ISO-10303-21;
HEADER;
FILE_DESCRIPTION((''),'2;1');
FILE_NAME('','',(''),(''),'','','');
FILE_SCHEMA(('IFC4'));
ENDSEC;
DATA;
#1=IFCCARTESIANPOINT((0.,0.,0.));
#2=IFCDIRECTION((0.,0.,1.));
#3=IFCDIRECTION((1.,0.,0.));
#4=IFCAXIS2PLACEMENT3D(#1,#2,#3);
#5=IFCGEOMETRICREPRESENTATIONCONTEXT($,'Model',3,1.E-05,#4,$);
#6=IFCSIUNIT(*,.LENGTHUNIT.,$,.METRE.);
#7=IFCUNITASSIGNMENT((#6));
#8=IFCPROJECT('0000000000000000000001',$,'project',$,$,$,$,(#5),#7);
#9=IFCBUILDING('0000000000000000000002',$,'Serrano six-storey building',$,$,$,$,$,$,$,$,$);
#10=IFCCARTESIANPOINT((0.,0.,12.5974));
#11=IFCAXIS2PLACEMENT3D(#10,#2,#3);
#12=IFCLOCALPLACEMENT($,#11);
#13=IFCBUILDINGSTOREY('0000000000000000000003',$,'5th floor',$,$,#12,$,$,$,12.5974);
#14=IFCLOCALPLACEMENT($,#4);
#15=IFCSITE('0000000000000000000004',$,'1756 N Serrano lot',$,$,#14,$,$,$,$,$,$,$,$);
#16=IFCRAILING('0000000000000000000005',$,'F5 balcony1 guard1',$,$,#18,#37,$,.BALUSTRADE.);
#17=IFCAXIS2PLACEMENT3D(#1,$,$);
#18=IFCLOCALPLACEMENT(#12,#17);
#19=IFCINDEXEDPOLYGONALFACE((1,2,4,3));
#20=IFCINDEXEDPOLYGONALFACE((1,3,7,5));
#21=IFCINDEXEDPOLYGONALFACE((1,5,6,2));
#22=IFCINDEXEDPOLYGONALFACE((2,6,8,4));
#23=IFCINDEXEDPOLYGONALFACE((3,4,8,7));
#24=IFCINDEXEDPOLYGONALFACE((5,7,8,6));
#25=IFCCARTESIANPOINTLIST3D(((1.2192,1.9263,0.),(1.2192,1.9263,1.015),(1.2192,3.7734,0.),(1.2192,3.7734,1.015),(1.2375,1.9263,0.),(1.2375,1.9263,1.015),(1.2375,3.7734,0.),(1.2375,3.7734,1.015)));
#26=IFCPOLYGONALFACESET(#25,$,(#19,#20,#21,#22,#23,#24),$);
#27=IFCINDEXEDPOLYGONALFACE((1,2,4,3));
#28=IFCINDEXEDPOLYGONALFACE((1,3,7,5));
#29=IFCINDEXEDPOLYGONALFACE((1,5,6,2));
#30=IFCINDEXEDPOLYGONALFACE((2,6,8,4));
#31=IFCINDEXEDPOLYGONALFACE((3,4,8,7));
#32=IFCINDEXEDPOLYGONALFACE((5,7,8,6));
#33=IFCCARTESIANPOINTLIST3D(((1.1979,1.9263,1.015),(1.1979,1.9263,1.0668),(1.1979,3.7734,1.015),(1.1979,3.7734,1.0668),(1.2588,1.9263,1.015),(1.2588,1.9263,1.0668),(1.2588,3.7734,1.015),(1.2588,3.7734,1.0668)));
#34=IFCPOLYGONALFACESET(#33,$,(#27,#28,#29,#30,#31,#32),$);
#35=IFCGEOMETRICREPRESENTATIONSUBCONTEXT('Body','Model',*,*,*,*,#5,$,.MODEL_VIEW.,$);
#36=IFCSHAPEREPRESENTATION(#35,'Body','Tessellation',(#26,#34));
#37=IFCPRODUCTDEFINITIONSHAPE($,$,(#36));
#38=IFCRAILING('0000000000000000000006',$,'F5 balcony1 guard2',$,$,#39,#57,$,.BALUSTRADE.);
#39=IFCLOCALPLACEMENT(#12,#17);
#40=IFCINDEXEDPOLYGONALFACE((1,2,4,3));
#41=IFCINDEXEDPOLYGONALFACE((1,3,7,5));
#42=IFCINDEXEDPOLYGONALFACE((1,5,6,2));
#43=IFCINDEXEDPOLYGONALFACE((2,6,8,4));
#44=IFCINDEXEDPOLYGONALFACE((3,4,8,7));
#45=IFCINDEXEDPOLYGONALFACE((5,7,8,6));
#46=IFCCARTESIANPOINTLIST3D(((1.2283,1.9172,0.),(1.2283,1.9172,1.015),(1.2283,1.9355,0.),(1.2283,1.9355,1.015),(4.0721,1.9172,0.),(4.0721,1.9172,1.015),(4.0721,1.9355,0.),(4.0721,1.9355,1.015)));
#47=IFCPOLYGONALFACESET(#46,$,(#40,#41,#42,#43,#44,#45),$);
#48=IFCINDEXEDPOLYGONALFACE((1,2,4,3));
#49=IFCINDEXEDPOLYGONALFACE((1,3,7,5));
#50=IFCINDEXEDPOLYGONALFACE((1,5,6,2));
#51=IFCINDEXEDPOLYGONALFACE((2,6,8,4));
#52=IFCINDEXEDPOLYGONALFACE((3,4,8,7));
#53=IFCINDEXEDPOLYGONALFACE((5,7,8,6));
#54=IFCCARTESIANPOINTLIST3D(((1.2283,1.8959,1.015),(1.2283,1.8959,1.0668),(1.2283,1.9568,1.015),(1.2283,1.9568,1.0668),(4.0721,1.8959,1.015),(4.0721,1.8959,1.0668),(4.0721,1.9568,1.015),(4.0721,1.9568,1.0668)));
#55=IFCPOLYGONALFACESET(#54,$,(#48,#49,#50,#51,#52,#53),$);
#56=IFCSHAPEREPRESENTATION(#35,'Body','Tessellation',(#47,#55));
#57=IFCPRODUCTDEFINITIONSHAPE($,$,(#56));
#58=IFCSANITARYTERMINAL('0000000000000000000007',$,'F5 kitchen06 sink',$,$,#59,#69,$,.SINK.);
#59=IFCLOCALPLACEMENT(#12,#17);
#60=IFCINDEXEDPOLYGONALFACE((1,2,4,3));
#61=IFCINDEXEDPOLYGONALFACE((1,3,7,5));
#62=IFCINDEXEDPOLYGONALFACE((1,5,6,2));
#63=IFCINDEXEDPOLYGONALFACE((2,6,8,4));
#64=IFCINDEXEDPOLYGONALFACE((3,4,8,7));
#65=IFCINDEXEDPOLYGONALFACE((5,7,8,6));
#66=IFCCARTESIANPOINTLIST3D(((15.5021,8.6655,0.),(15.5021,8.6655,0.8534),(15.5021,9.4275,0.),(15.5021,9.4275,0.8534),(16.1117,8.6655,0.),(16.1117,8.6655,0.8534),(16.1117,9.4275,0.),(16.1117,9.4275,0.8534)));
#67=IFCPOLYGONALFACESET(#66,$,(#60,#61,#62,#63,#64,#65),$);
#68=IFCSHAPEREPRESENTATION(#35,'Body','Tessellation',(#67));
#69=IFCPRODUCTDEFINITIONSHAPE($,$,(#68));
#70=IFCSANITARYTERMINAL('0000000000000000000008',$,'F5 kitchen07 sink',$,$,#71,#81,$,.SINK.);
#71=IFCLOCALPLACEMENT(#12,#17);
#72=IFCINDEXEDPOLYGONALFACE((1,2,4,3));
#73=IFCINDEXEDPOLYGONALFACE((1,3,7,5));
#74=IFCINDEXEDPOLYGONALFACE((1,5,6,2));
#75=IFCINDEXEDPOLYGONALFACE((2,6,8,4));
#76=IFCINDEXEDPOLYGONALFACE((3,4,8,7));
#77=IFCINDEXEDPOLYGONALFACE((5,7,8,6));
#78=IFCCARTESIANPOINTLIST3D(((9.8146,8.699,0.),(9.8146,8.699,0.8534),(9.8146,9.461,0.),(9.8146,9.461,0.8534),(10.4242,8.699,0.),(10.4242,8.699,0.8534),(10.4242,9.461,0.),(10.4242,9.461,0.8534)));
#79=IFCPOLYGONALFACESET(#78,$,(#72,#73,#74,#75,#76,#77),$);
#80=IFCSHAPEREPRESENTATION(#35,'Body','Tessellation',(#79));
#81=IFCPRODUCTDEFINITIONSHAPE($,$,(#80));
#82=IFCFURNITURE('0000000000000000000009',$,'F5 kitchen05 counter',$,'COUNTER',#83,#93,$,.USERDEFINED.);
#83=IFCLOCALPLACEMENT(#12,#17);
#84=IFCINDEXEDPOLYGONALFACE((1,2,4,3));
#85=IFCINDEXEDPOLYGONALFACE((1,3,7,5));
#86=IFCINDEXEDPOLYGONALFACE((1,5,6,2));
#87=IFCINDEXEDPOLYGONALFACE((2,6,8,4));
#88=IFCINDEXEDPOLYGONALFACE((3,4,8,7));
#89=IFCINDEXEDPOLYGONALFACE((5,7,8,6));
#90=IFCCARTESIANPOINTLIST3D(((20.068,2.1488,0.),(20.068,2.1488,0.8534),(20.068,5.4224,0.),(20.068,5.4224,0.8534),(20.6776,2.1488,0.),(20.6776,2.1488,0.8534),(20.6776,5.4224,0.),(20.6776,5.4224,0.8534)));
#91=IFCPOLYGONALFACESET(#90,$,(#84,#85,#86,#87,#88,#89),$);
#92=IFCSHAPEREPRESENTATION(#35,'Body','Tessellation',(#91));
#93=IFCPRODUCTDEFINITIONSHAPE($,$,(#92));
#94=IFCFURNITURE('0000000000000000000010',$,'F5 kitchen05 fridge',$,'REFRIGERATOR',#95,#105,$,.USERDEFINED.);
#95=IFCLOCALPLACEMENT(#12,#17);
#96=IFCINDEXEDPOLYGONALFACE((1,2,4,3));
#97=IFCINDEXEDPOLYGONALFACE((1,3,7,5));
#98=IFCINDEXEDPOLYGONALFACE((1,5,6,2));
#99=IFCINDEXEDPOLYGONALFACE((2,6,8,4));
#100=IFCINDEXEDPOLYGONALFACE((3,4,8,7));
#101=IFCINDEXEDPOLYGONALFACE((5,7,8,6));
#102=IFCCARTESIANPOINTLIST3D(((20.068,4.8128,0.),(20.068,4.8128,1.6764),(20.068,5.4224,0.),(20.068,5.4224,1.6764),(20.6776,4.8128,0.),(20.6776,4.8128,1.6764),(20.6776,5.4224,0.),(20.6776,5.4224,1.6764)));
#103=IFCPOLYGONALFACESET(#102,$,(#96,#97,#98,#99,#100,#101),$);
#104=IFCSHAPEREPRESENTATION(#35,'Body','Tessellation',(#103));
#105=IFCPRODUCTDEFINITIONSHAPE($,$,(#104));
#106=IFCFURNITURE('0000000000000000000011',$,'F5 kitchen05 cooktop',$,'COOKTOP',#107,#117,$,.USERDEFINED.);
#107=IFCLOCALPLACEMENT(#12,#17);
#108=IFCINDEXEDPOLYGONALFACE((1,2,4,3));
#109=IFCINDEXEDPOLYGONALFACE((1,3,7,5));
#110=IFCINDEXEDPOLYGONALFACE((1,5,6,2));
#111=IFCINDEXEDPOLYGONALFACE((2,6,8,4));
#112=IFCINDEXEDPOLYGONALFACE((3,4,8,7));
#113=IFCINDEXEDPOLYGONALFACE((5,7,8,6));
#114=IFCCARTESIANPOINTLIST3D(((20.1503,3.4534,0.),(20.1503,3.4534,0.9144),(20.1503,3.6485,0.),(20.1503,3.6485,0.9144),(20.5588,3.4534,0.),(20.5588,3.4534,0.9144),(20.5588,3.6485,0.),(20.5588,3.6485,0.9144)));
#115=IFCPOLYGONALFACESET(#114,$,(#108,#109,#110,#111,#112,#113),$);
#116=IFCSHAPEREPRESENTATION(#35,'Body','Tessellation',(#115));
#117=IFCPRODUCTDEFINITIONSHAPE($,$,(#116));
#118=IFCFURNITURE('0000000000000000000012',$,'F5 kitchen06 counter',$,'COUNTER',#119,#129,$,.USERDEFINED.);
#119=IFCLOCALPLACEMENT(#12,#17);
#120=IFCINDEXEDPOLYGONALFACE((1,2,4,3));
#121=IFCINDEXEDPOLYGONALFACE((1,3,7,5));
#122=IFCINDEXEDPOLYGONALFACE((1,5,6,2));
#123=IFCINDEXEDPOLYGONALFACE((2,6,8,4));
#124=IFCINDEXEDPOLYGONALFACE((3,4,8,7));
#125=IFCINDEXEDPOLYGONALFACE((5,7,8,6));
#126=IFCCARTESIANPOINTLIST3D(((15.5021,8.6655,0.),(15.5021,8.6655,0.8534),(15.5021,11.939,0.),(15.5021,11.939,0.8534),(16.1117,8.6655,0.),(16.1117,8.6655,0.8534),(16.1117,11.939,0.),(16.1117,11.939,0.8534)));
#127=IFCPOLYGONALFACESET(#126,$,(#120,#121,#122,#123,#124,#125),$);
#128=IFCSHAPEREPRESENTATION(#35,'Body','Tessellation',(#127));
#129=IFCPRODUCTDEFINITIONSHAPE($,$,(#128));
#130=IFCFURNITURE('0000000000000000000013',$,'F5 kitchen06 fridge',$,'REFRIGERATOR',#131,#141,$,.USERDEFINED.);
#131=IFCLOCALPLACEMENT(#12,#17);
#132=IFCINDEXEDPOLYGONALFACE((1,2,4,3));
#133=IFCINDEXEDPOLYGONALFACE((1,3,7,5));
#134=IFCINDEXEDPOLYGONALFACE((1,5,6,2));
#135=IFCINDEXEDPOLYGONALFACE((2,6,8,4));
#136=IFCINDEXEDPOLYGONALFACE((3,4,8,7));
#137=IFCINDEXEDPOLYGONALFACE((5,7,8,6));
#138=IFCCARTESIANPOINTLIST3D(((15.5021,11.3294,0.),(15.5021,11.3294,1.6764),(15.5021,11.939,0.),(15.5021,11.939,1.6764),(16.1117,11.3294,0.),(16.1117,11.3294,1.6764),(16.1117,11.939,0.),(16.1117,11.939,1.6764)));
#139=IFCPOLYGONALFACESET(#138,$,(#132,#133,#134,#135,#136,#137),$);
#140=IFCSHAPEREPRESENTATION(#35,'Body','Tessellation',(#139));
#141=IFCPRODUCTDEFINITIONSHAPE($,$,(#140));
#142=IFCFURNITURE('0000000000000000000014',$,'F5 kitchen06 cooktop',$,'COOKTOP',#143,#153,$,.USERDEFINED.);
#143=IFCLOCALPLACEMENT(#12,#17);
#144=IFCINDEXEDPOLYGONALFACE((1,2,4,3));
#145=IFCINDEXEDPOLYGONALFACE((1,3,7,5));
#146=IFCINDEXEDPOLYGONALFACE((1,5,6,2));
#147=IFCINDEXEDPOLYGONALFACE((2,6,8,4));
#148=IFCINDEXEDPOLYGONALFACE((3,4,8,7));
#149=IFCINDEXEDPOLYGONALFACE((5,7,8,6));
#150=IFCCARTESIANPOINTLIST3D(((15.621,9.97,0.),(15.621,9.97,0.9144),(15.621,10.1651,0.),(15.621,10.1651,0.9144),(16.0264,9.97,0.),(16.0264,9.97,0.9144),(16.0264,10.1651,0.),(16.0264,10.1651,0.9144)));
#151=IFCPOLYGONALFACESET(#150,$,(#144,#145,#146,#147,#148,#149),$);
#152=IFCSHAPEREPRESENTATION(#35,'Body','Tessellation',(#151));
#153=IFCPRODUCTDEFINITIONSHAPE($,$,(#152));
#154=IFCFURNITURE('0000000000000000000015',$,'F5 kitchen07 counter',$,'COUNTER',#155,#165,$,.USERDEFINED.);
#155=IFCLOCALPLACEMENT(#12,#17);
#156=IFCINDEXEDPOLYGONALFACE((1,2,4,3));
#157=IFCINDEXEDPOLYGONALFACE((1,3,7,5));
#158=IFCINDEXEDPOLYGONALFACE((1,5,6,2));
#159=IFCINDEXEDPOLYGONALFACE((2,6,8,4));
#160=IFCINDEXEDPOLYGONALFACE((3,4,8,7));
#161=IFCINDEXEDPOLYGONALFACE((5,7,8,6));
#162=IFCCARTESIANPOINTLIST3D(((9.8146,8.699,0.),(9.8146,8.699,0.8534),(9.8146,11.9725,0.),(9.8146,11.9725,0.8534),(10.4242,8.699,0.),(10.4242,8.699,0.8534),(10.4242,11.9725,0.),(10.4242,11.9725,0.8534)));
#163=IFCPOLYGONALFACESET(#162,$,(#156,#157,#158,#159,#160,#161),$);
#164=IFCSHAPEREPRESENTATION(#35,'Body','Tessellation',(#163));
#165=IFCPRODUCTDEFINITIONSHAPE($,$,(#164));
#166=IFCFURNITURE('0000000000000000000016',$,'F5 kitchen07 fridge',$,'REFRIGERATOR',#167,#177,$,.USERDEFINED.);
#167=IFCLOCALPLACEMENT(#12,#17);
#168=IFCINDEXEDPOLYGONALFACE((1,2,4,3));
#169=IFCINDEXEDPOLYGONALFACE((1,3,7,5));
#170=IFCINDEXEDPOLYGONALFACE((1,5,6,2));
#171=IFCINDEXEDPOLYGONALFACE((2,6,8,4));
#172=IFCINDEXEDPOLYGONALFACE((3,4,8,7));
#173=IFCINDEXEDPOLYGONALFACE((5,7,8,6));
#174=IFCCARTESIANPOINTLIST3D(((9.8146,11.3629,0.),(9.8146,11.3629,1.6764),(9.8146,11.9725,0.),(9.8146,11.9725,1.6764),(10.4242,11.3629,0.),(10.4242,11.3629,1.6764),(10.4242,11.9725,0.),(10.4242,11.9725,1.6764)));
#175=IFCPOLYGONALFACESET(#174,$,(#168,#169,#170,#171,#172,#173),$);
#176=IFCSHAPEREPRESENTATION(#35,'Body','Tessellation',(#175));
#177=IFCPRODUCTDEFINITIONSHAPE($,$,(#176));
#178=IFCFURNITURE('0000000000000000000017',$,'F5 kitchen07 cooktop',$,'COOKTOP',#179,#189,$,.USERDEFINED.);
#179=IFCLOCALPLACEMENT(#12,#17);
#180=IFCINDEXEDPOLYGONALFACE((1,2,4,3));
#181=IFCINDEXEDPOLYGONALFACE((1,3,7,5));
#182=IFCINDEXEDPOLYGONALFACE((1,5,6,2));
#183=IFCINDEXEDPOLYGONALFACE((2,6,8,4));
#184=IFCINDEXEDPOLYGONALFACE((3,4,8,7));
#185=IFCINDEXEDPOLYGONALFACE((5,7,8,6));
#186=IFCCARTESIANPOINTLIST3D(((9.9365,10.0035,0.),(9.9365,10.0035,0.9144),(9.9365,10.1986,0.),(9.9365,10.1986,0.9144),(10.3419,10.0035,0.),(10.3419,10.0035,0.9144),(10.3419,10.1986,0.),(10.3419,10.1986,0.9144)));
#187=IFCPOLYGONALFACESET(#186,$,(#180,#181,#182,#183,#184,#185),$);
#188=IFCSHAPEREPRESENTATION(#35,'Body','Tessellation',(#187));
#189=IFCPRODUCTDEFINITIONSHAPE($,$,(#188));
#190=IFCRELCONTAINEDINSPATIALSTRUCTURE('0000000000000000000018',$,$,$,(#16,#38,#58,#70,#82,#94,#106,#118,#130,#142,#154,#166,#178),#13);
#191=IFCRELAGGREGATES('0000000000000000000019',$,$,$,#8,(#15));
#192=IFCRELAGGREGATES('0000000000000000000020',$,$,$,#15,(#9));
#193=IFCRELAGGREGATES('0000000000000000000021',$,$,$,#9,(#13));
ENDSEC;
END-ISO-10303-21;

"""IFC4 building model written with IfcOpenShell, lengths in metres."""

from ifc_helpers import new_model, si_unit, frame, origin_with_axes, place, context, subcontext, project, spatial, polyline, outline, extrude, element, save


model = new_model("IFC4")

# Units and contexts
model_context = context("Model", 3, precision=1e-05, world=origin_with_axes())
body_context = subcontext(model_context, "Body", "Model", "MODEL_VIEW")
ifc_project = project(units=[si_unit("LENGTHUNIT", "METRE")], contexts=[model_context])

# Site, building, storey
site_placement = place(None, origin_with_axes())
site = spatial("IfcSite", under=ifc_project, at=site_placement, Name="1756 N Serrano lot")
building = spatial("IfcBuilding", under=site, Name="Serrano six-storey building")
storey_placement = place(None, frame((0.0, 0.0, 12.5974), z_axis=(0.0, 0.0, 1.0), x_axis=(1.0, 0.0, 0.0)))
storey = spatial("IfcBuildingStorey", under=building, at=storey_placement, Name="5th floor", Elevation=12.5974)

# Railings
railing_1_placement = place(storey_placement, frame((0.0, 0.0, -12.5974), z_axis=(0.0, 0.0, 1.0), x_axis=(1.0, 0.0, 0.0)))
element("IfcRailing", 1, at=railing_1_placement, inside=storey, Name="F5 balcony1 guard1", PredefinedType="BALUSTRADE", context=body_context, shape_type="SweptSolid", body=[
    extrude(outline(polyline([(1.2192, 3.7734), (1.2375, 3.7734), (1.2375, 1.9263), (1.2192, 1.9263), (1.2192, 3.7734)])), frame((0.0, 0.0, 12.5974)), (0.0, 0.0, 1.0), 1.015),
    extrude(outline(polyline([(1.1979, 3.7734), (1.2588, 3.7734), (1.2588, 1.9263), (1.1979, 1.9263), (1.1979, 3.7734)])), frame((0.0, 0.0, 13.6124)), (0.0, 0.0, 1.0), 0.0518),
])
railing_2_placement = place(storey_placement, frame((0.0, 0.0, -12.5974), z_axis=(0.0, 0.0, 1.0), x_axis=(1.0, 0.0, 0.0)))
element("IfcRailing", 2, at=railing_2_placement, inside=storey, Name="F5 balcony1 guard2", PredefinedType="BALUSTRADE", context=body_context, shape_type="SweptSolid", body=[
    extrude(outline(polyline([(1.2283, 1.9172), (1.2283, 1.9355), (4.0721, 1.9355), (4.0721, 1.9172), (1.2283, 1.9172)])), frame((0.0, 0.0, 12.5974)), (0.0, 0.0, 1.0), 1.015),
    extrude(outline(polyline([(1.2283, 1.8959), (1.2283, 1.9568), (4.0721, 1.9568), (4.0721, 1.8959), (1.2283, 1.8959)])), frame((0.0, 0.0, 13.6124)), (0.0, 0.0, 1.0), 0.0518),
])

# Sanitary terminals
sanitary_terminal_1_placement = place(storey_placement, frame((0.0, 0.0, -12.5974), z_axis=(0.0, 0.0, 1.0), x_axis=(1.0, 0.0, 0.0)))
element("IfcSanitaryTerminal", 3, at=sanitary_terminal_1_placement, inside=storey, Name="F5 kitchen06 sink", PredefinedType="SINK", context=body_context, shape_type="SweptSolid", body=[
    extrude(outline(polyline([(16.1117, 8.6655), (16.1117, 9.4275), (15.5021, 9.4275), (15.5021, 8.6655), (16.1117, 8.6655)])), frame((0.0, 0.0, 12.5974)), (0.0, 0.0, 1.0), 0.8534),
])
sanitary_terminal_2_placement = place(storey_placement, frame((0.0, 0.0, -12.5974), z_axis=(0.0, 0.0, 1.0), x_axis=(1.0, 0.0, 0.0)))
element("IfcSanitaryTerminal", 4, at=sanitary_terminal_2_placement, inside=storey, Name="F5 kitchen07 sink", PredefinedType="SINK", context=body_context, shape_type="SweptSolid", body=[
    extrude(outline(polyline([(10.4242, 8.699), (10.4242, 9.461), (9.8146, 9.461), (9.8146, 8.699), (10.4242, 8.699)])), frame((0.0, 0.0, 12.5974)), (0.0, 0.0, 1.0), 0.8534),
])

# Furniture
furniture_1_placement = place(storey_placement, frame((0.0, 0.0, -12.5974), z_axis=(0.0, 0.0, 1.0), x_axis=(1.0, 0.0, 0.0)))
element("IfcFurniture", 5, at=furniture_1_placement, inside=storey, Name="F5 kitchen05 counter", ObjectType="COUNTER", PredefinedType="USERDEFINED", context=body_context, shape_type="SweptSolid", body=[
    extrude(outline(polyline([(20.6776, 2.1488), (20.6776, 5.4224), (20.068, 5.4224), (20.068, 2.1488), (20.6776, 2.1488)])), frame((0.0, 0.0, 12.5974)), (0.0, 0.0, 1.0), 0.8534),
])
furniture_2_placement = place(storey_placement, frame((0.0, 0.0, -12.5974), z_axis=(0.0, 0.0, 1.0), x_axis=(1.0, 0.0, 0.0)))
element("IfcFurniture", 6, at=furniture_2_placement, inside=storey, Name="F5 kitchen05 fridge", ObjectType="REFRIGERATOR", PredefinedType="USERDEFINED", context=body_context, shape_type="SweptSolid", body=[
    extrude(outline(polyline([(20.6776, 4.8128), (20.6776, 5.4224), (20.068, 5.4224), (20.068, 4.8128), (20.6776, 4.8128)])), frame((0.0, 0.0, 12.5974)), (0.0, 0.0, 1.0), 1.6764),
])
furniture_3_placement = place(storey_placement, frame((0.0, 0.0, -12.5974), z_axis=(0.0, 0.0, 1.0), x_axis=(1.0, 0.0, 0.0)))
element("IfcFurniture", 7, at=furniture_3_placement, inside=storey, Name="F5 kitchen05 cooktop", ObjectType="COOKTOP", PredefinedType="USERDEFINED", context=body_context, shape_type="SweptSolid", body=[
    extrude(outline(polyline([(20.5588, 3.4534), (20.5588, 3.6485), (20.1503, 3.6485), (20.1503, 3.4534), (20.5588, 3.4534)])), frame((0.0, 0.0, 12.5974)), (0.0, 0.0, 1.0), 0.9144),
])
furniture_4_placement = place(storey_placement, frame((0.0, 0.0, -12.5974), z_axis=(0.0, 0.0, 1.0), x_axis=(1.0, 0.0, 0.0)))
element("IfcFurniture", 8, at=furniture_4_placement, inside=storey, Name="F5 kitchen06 counter", ObjectType="COUNTER", PredefinedType="USERDEFINED", context=body_context, shape_type="SweptSolid", body=[
    extrude(outline(polyline([(16.1117, 8.6655), (16.1117, 11.939), (15.5021, 11.939), (15.5021, 8.6655), (16.1117, 8.6655)])), frame((0.0, 0.0, 12.5974)), (0.0, 0.0, 1.0), 0.8534),
])
furniture_5_placement = place(storey_placement, frame((0.0, 0.0, -12.5974), z_axis=(0.0, 0.0, 1.0), x_axis=(1.0, 0.0, 0.0)))
element("IfcFurniture", 9, at=furniture_5_placement, inside=storey, Name="F5 kitchen06 fridge", ObjectType="REFRIGERATOR", PredefinedType="USERDEFINED", context=body_context, shape_type="SweptSolid", body=[
    extrude(outline(polyline([(16.1117, 11.3294), (16.1117, 11.939), (15.5021, 11.939), (15.5021, 11.3294), (16.1117, 11.3294)])), frame((0.0, 0.0, 12.5974)), (0.0, 0.0, 1.0), 1.6764),
])
furniture_6_placement = place(storey_placement, frame((0.0, 0.0, -12.5974), z_axis=(0.0, 0.0, 1.0), x_axis=(1.0, 0.0, 0.0)))
element("IfcFurniture", 10, at=furniture_6_placement, inside=storey, Name="F5 kitchen06 cooktop", ObjectType="COOKTOP", PredefinedType="USERDEFINED", context=body_context, shape_type="SweptSolid", body=[
    extrude(outline(polyline([(16.0264, 9.97), (16.0264, 10.1651), (15.621, 10.1651), (15.621, 9.97), (16.0264, 9.97)])), frame((0.0, 0.0, 12.5974)), (0.0, 0.0, 1.0), 0.9144),
])
furniture_7_placement = place(storey_placement, frame((0.0, 0.0, -12.5974), z_axis=(0.0, 0.0, 1.0), x_axis=(1.0, 0.0, 0.0)))
element("IfcFurniture", 11, at=furniture_7_placement, inside=storey, Name="F5 kitchen07 counter", ObjectType="COUNTER", PredefinedType="USERDEFINED", context=body_context, shape_type="SweptSolid", body=[
    extrude(outline(polyline([(10.4242, 8.699), (10.4242, 11.9725), (9.8146, 11.9725), (9.8146, 8.699), (10.4242, 8.699)])), frame((0.0, 0.0, 12.5974)), (0.0, 0.0, 1.0), 0.8534),
])
furniture_8_placement = place(storey_placement, frame((0.0, 0.0, -12.5974), z_axis=(0.0, 0.0, 1.0), x_axis=(1.0, 0.0, 0.0)))
element("IfcFurniture", 12, at=furniture_8_placement, inside=storey, Name="F5 kitchen07 fridge", ObjectType="REFRIGERATOR", PredefinedType="USERDEFINED", context=body_context, shape_type="SweptSolid", body=[
    extrude(outline(polyline([(10.4242, 11.3629), (10.4242, 11.9725), (9.8146, 11.9725), (9.8146, 11.3629), (10.4242, 11.3629)])), frame((0.0, 0.0, 12.5974)), (0.0, 0.0, 1.0), 1.6764),
])
furniture_9_placement = place(storey_placement, frame((0.0, 0.0, -12.5974), z_axis=(0.0, 0.0, 1.0), x_axis=(1.0, 0.0, 0.0)))
element("IfcFurniture", 13, at=furniture_9_placement, inside=storey, Name="F5 kitchen07 cooktop", ObjectType="COOKTOP", PredefinedType="USERDEFINED", context=body_context, shape_type="SweptSolid", body=[
    extrude(outline(polyline([(10.3419, 10.0035), (10.3419, 10.1986), (9.9365, 10.1986), (9.9365, 10.0035), (10.3419, 10.0035)])), frame((0.0, 0.0, 12.5974)), (0.0, 0.0, 1.0), 0.9144),
])

save(model, "model.ifc")
